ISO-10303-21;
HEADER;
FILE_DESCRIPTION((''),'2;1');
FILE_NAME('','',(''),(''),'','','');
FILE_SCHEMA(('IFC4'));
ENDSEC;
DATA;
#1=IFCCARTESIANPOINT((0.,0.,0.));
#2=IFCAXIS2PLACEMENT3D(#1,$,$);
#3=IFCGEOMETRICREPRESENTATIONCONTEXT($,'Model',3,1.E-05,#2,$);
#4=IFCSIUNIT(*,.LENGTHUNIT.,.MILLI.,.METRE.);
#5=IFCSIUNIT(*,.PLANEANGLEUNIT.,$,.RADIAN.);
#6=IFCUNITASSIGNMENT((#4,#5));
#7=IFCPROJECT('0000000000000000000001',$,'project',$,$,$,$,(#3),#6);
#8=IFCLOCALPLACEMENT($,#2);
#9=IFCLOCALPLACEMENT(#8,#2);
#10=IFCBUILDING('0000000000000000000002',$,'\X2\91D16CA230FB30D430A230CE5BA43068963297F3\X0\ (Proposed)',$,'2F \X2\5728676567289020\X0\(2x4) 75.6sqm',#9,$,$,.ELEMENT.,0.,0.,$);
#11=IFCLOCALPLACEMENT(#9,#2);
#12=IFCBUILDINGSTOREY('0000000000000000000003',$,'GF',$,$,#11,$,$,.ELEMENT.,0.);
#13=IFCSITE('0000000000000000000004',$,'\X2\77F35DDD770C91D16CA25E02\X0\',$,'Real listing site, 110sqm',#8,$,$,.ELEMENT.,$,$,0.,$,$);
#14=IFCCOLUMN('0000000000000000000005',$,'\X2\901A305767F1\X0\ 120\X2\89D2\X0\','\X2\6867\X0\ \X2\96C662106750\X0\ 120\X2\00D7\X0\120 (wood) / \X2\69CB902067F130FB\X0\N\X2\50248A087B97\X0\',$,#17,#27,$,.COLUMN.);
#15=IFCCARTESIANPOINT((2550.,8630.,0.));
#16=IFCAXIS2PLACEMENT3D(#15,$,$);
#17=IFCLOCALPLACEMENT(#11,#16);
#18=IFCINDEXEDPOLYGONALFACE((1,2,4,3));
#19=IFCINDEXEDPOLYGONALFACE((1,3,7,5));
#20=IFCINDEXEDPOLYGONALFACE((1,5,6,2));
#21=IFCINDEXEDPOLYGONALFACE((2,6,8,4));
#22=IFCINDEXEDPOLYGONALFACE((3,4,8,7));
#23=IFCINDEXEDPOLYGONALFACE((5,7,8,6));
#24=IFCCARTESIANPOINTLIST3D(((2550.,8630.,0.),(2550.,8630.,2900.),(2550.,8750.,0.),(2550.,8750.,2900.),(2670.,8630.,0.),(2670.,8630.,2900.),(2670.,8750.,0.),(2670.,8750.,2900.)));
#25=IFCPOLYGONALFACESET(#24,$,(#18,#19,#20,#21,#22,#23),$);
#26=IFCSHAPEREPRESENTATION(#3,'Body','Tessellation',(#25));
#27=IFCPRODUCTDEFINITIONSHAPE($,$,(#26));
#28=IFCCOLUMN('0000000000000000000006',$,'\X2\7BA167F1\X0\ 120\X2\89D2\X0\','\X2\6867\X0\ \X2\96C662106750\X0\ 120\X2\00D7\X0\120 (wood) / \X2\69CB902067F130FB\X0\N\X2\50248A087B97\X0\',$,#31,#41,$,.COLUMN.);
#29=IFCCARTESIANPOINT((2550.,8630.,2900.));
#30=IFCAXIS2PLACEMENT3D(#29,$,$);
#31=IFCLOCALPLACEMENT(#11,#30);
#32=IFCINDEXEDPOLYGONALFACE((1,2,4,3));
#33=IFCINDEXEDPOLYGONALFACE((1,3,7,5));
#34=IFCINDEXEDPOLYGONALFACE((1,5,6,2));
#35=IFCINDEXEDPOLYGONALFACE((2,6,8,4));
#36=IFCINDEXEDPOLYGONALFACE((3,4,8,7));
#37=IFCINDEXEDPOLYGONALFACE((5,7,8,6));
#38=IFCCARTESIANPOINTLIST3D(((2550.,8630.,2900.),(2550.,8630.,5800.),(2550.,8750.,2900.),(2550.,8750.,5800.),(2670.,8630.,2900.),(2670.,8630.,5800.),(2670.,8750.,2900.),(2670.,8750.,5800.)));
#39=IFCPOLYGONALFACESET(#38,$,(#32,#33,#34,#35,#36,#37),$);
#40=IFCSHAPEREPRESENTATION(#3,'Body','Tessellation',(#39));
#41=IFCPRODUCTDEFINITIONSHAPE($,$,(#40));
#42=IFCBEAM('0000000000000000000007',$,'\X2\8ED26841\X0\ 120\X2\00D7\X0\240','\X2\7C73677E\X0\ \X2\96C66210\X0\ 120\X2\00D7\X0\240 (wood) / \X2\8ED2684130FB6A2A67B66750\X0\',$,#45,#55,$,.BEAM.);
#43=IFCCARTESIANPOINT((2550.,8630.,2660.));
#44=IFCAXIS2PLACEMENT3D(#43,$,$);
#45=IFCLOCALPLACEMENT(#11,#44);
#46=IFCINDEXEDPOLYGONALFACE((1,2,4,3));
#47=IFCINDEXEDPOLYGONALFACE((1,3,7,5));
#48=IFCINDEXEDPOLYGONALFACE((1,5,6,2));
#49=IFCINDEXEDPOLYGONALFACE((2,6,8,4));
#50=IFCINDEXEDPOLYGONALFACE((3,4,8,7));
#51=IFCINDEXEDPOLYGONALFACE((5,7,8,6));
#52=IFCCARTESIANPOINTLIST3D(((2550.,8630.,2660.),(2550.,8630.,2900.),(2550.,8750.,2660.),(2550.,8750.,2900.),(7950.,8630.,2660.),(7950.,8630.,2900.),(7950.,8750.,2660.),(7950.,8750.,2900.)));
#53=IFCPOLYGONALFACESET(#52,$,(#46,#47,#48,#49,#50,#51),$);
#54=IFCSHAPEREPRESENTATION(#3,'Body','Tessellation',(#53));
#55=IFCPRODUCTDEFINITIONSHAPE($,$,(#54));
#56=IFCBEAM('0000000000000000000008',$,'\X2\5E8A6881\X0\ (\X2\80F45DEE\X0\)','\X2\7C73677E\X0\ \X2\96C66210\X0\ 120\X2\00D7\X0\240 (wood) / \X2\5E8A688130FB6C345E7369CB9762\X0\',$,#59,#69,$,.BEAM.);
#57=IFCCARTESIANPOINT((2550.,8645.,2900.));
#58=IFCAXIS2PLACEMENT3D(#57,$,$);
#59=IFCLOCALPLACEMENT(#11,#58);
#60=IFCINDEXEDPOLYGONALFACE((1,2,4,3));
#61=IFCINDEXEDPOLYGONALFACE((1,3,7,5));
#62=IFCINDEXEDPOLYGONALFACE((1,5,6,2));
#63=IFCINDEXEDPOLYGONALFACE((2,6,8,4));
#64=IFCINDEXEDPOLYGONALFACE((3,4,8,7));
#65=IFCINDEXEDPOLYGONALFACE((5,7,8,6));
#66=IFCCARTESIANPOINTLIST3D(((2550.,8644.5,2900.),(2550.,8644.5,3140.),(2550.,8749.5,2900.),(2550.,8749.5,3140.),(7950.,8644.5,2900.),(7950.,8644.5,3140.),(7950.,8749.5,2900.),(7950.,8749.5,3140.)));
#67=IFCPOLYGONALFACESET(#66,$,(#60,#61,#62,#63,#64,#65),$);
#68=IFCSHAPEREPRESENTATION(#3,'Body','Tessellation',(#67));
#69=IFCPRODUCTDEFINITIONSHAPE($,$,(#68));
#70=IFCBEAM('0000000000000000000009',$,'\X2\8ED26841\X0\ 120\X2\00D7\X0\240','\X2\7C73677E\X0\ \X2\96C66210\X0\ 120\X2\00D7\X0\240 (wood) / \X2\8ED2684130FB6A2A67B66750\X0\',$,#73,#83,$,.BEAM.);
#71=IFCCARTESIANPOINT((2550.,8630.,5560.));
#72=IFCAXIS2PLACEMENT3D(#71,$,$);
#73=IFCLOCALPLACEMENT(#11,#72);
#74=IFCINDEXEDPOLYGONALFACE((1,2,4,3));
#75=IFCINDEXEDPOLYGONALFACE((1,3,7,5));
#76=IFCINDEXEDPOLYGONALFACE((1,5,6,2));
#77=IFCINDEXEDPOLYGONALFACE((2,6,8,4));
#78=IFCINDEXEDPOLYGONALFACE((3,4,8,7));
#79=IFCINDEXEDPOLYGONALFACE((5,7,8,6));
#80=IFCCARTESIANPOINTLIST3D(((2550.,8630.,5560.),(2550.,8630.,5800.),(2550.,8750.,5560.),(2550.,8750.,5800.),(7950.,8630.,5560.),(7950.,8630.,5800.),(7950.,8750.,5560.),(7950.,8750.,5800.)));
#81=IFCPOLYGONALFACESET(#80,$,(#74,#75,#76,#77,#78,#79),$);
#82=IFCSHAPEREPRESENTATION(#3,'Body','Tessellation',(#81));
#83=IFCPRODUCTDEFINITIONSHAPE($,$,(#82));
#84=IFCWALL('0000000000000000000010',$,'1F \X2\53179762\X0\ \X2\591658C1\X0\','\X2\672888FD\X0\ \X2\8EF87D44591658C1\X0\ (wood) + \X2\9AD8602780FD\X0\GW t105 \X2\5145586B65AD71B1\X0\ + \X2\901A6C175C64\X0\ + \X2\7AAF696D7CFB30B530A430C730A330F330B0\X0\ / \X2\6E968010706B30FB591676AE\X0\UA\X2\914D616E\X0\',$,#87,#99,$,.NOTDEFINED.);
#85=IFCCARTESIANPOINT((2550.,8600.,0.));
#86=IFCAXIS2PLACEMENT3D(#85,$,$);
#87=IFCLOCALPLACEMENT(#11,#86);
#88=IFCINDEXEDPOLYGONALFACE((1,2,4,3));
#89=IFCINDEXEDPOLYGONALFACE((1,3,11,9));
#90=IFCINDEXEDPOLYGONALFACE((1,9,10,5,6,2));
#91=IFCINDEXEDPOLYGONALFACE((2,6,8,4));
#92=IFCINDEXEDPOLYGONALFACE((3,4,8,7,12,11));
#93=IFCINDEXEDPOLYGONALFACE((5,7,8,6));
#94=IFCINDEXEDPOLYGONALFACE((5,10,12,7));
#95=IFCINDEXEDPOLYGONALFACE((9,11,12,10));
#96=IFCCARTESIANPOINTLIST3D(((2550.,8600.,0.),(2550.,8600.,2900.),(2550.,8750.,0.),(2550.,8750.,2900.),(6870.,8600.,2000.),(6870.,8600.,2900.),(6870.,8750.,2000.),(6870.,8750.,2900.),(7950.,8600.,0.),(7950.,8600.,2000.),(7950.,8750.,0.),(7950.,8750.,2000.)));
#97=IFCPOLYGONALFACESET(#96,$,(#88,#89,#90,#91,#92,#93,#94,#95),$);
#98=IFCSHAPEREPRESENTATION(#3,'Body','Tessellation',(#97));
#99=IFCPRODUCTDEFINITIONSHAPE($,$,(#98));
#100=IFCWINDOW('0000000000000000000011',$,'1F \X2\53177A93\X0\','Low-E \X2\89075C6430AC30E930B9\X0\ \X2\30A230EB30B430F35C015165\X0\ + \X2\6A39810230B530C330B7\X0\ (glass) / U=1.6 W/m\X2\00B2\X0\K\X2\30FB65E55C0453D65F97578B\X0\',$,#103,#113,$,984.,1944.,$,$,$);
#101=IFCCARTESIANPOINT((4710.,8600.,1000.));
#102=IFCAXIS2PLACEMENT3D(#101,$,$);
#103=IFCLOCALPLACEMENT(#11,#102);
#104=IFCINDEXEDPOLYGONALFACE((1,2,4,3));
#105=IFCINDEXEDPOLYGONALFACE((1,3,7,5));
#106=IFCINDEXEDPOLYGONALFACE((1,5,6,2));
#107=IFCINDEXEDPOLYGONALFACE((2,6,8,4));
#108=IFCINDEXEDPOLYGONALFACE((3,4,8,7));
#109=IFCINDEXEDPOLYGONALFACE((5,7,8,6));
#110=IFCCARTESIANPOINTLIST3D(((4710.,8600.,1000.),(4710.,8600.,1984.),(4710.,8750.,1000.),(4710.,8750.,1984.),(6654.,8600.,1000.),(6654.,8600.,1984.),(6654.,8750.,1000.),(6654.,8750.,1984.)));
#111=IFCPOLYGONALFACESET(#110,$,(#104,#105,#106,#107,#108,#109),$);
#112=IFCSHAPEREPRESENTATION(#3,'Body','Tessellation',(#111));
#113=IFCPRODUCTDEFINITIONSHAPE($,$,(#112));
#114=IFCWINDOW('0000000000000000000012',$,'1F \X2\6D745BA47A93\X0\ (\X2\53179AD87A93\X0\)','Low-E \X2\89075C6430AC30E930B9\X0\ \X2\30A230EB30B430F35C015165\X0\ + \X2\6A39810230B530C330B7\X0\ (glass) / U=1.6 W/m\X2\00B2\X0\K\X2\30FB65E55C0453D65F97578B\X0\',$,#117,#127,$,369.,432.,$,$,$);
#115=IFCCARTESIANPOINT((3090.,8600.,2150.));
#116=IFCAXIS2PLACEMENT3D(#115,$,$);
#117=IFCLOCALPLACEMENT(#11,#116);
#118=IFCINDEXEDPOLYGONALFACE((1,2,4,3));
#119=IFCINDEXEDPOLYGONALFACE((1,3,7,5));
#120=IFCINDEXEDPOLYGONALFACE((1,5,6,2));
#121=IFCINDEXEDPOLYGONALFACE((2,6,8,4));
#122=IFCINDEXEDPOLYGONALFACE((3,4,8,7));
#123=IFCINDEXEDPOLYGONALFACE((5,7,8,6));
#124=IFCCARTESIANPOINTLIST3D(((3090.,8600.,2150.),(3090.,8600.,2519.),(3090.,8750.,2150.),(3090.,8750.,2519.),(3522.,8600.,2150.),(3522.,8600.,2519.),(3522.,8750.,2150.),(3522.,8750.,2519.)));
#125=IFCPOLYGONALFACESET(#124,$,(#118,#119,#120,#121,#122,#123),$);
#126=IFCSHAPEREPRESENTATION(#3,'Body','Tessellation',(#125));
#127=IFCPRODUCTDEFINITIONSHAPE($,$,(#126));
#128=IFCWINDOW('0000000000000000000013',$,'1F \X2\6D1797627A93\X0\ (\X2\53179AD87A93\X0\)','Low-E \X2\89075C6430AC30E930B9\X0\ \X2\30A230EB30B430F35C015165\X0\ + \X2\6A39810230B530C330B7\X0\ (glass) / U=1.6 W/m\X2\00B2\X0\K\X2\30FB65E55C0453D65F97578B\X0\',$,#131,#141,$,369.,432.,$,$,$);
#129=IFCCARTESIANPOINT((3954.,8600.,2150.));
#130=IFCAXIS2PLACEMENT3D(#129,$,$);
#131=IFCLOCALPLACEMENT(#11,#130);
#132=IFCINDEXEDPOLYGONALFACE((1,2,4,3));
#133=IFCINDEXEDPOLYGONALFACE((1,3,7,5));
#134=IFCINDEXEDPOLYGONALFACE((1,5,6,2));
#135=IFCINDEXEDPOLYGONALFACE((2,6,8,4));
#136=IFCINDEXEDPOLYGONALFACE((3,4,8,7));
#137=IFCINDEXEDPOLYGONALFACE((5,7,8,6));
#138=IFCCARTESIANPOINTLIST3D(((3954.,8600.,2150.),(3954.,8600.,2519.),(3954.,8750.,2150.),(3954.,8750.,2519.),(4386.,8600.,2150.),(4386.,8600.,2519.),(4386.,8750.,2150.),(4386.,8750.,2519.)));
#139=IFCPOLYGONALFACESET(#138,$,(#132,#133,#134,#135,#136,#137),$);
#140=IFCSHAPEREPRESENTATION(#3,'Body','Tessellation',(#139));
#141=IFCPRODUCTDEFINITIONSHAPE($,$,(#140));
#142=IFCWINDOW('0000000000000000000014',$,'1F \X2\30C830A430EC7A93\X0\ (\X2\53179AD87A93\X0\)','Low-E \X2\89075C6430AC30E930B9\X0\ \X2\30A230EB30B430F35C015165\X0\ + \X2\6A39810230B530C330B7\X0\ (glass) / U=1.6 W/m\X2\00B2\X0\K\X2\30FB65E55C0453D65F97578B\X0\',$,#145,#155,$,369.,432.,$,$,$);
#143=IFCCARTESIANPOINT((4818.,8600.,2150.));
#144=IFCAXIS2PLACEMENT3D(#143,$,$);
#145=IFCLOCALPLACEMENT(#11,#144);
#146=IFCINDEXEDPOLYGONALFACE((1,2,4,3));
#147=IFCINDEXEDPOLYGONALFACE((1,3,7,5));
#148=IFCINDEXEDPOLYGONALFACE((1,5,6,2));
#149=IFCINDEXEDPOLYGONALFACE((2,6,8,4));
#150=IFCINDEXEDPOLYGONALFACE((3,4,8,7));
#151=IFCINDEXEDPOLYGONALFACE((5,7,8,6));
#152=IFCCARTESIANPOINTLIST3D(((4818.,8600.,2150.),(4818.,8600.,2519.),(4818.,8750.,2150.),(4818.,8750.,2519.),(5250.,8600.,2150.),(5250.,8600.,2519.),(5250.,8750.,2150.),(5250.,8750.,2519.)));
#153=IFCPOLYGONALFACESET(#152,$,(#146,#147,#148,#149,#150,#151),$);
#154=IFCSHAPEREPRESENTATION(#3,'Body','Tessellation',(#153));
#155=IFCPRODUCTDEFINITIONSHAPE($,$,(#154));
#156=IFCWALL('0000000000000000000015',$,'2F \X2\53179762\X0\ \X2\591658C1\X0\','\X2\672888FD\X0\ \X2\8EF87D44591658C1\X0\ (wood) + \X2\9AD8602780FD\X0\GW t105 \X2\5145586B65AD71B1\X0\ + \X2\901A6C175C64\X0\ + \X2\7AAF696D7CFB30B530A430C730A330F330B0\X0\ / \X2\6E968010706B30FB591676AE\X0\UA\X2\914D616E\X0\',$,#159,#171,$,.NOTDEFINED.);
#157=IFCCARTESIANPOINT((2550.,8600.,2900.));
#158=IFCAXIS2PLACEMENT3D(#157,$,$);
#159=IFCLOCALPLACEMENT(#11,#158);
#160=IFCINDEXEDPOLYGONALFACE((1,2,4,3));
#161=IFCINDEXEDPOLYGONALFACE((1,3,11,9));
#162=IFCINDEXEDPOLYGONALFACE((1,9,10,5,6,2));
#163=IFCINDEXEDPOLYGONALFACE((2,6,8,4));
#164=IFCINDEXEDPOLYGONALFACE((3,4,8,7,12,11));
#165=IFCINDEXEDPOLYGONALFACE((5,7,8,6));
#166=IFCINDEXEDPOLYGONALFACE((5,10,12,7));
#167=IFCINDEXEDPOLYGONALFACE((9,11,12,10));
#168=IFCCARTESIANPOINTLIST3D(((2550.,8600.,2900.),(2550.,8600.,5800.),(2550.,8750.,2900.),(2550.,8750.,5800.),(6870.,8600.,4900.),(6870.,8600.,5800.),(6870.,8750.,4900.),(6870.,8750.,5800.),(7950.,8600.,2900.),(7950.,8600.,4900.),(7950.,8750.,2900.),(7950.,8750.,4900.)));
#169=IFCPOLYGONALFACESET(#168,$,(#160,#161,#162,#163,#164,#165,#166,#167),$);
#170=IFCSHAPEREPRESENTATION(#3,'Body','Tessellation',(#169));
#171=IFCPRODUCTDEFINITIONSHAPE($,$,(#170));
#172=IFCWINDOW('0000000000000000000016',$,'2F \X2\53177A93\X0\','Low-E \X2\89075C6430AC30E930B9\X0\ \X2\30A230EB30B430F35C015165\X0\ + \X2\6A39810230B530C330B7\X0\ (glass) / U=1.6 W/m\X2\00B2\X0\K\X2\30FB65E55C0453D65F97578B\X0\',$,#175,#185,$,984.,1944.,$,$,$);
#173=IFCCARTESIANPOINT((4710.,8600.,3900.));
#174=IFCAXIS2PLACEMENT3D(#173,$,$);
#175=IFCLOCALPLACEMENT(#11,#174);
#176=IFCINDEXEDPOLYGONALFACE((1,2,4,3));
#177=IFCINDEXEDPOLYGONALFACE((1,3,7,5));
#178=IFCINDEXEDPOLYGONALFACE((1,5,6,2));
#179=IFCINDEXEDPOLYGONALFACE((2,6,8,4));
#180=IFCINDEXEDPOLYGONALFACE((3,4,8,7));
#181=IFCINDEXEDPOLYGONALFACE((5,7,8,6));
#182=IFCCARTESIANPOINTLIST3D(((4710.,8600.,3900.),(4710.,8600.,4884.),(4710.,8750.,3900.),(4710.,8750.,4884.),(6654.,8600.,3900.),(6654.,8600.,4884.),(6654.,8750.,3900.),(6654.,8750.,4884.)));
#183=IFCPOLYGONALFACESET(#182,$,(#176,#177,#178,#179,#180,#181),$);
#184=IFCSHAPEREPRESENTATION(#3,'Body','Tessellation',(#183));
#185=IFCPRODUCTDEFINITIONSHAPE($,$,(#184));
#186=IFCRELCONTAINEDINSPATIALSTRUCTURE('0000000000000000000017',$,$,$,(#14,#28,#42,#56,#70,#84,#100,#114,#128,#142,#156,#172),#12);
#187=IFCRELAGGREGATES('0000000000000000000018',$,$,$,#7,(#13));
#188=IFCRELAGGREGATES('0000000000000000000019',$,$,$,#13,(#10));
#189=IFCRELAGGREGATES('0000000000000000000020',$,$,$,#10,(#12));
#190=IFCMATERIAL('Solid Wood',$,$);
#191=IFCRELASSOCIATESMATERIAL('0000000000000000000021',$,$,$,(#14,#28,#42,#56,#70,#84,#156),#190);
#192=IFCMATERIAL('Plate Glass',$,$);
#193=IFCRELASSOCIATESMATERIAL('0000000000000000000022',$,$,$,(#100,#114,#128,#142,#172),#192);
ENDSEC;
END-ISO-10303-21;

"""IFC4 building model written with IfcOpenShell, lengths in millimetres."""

from ifc_helpers import new_model, si_unit, frame, frame_2d, origin, place, context, project, spatial, rectangle, extrude, material, element, fill, save


model = new_model("IFC4")

# Units and contexts
model_context = context("Model", 3, precision=1e-05, world=origin())
ifc_project = project(units=[si_unit("LENGTHUNIT", "METRE", prefix="MILLI"), si_unit("PLANEANGLEUNIT", "RADIAN")], contexts=[model_context])

# Site, building, storey
site_placement = place(None, origin())
site = spatial("IfcSite", under=ifc_project, at=site_placement, Name="石川県金沢市", ObjectType="Real listing site, 110sqm", CompositionType="ELEMENT", RefElevation=0.0)
building_placement = place(site_placement, origin())
building = spatial("IfcBuilding", under=site, at=building_placement, Name="金沢・ピアノ室と防音 (Proposed)", ObjectType="2F 在来木造(2x4) 75.6sqm", CompositionType="ELEMENT", ElevationOfRefHeight=0.0, ElevationOfTerrain=0.0)
storey_placement = place(building_placement, origin())
storey = spatial("IfcBuildingStorey", under=building, at=storey_placement, Name="GF", CompositionType="ELEMENT", Elevation=0.0)

# Columns
ifc_material_1 = material(Name="Solid Wood")
column_1_placement = place(storey_placement, frame((2550.0, 8630.0, 0.0)))
element("IfcColumn", 1, at=column_1_placement, inside=storey, material=ifc_material_1, Name="通し柱 120角", Description="桧 集成材 120×120 (wood) / 構造柱・N値計算", PredefinedType="COLUMN", context=model_context, shape_type="SweptSolid", body=[
    extrude(rectangle(XDim=120.0, YDim=120.0, at=frame_2d((60.0, 60.0))), frame((2550.0, 8630.0, 0.0)), (0.0, 0.0, 1.0), 2900.0),
])
column_2_placement = place(storey_placement, frame((2550.0, 8630.0, 2900.0)))
element("IfcColumn", 2, at=column_2_placement, inside=storey, material=ifc_material_1, Name="管柱 120角", Description="桧 集成材 120×120 (wood) / 構造柱・N値計算", PredefinedType="COLUMN", context=model_context, shape_type="SweptSolid", body=[
    extrude(rectangle(XDim=120.0, YDim=120.0, at=frame_2d((60.0, 60.0))), frame((2550.0, 8630.0, 2900.0)), (0.0, 0.0, 1.0), 2900.0),
])

# Beams
beam_1_placement = place(storey_placement, frame((2550.0, 8630.0, 2660.0)))
element("IfcBeam", 3, at=beam_1_placement, inside=storey, material=ifc_material_1, Name="軒桁 120×240", Description="米松 集成 120×240 (wood) / 軒桁・横架材", PredefinedType="BEAM", context=model_context, shape_type="SweptSolid", body=[
    extrude(rectangle(XDim=5400.0, YDim=120.0, at=frame_2d((2700.0, 60.0))), frame((2550.0, 8630.0, 2660.0)), (0.0, 0.0, 1.0), 240.0),
])
beam_2_placement = place(storey_placement, frame((2550.0, 8645.0, 2900.0)))
element("IfcBeam", 4, at=beam_2_placement, inside=storey, material=ifc_material_1, Name="床梁 (胴差)", Description="米松 集成 120×240 (wood) / 床梁・水平構面", PredefinedType="BEAM", context=model_context, shape_type="SweptSolid", body=[
    extrude(rectangle(XDim=5400.0, YDim=105.0, at=frame_2d((2700.0, 52.0))), frame((2550.0, 8645.0, 2900.0)), (0.0, 0.0, 1.0), 240.0),
])
beam_3_placement = place(storey_placement, frame((2550.0, 8630.0, 5560.0)))
element("IfcBeam", 5, at=beam_3_placement, inside=storey, material=ifc_material_1, Name="軒桁 120×240", Description="米松 集成 120×240 (wood) / 軒桁・横架材", PredefinedType="BEAM", context=model_context, shape_type="SweptSolid", body=[
    extrude(rectangle(XDim=5400.0, YDim=120.0, at=frame_2d((2700.0, 60.0))), frame((2550.0, 8630.0, 5560.0)), (0.0, 0.0, 1.0), 240.0),
])

# Wall, openings, windows
wall_1_placement = place(storey_placement, frame((2550.0, 8600.0, 0.0)))
wall_1 = element("IfcWall", 6, at=wall_1_placement, inside=storey, material=ifc_material_1, Name="1F 北面 外壁", Description="木製 軸組外壁 (wood) + 高性能GW t105 充填断熱 + 通気層 + 窯業系サイディング / 準耐火・外皮UA配慮", PredefinedType="NOTDEFINED", context=model_context, shape_type="SweptSolid", body=[
    extrude(rectangle(XDim=5400.0, YDim=150.0, at=frame_2d((2700.0, 75.0))), frame((2550.0, 8600.0, 0.0)), (0.0, 0.0, 1.0), 2900.0),
])
opening_1_placement = place(storey_placement, frame((4710.0, 8600.0, 1000.0)))
opening_1 = element("IfcOpeningElement", 7, at=opening_1_placement, cuts=wall_1, PredefinedType="NOTDEFINED", context=model_context, shape_type="SweptSolid", body=[
    extrude(rectangle(XDim=1944.0, YDim=150.0, at=frame_2d((972.0, 75.0))), frame((4710.0, 8600.0, 1000.0)), (0.0, 0.0, 1.0), 984.0),
])
opening_2_placement = place(storey_placement, frame((3090.0, 8600.0, 2150.0)))
opening_2 = element("IfcOpeningElement", 8, at=opening_2_placement, cuts=wall_1, PredefinedType="NOTDEFINED", context=model_context, shape_type="SweptSolid", body=[
    extrude(rectangle(XDim=432.0, YDim=150.0, at=frame_2d((216.0, 75.0))), frame((3090.0, 8600.0, 2150.0)), (0.0, 0.0, 1.0), 369.0),
])
opening_3_placement = place(storey_placement, frame((3954.0, 8600.0, 2150.0)))
opening_3 = element("IfcOpeningElement", 9, at=opening_3_placement, cuts=wall_1, PredefinedType="NOTDEFINED", context=model_context, shape_type="SweptSolid", body=[
    extrude(rectangle(XDim=432.0, YDim=150.0, at=frame_2d((216.0, 75.0))), frame((3954.0, 8600.0, 2150.0)), (0.0, 0.0, 1.0), 369.0),
])
opening_4_placement = place(storey_placement, frame((4818.0, 8600.0, 2150.0)))
opening_4 = element("IfcOpeningElement", 10, at=opening_4_placement, cuts=wall_1, PredefinedType="NOTDEFINED", context=model_context, shape_type="SweptSolid", body=[
    extrude(rectangle(XDim=432.0, YDim=150.0, at=frame_2d((216.0, 75.0))), frame((4818.0, 8600.0, 2150.0)), (0.0, 0.0, 1.0), 369.0),
])
ifc_material_2 = material(Name="Plate Glass")
window_1_placement = place(storey_placement, frame((4710.0, 8600.0, 1000.0)))
window_1 = element("IfcWindow", 11, at=window_1_placement, inside=storey, material=ifc_material_2, Name="1F 北窓", Description="Low-E 複層ガラス アルゴン封入 + 樹脂サッシ (glass) / U=1.6 W/m²K・日射取得型", OverallHeight=984.0, OverallWidth=1944.0, context=model_context, shape_type="SweptSolid", body=[
    extrude(rectangle(XDim=1944.0, YDim=150.0, at=frame_2d((972.0, 75.0))), frame((4710.0, 8600.0, 1000.0)), (0.0, 0.0, 1.0), 984.0),
])
fill(opening_1, window_1)
window_2_placement = place(storey_placement, frame((3090.0, 8600.0, 2150.0)))
window_2 = element("IfcWindow", 12, at=window_2_placement, inside=storey, material=ifc_material_2, Name="1F 浴室窓 (北高窓)", Description="Low-E 複層ガラス アルゴン封入 + 樹脂サッシ (glass) / U=1.6 W/m²K・日射取得型", OverallHeight=369.0, OverallWidth=432.0, context=model_context, shape_type="SweptSolid", body=[
    extrude(rectangle(XDim=432.0, YDim=150.0, at=frame_2d((216.0, 75.0))), frame((3090.0, 8600.0, 2150.0)), (0.0, 0.0, 1.0), 369.0),
])
fill(opening_2, window_2)
window_3_placement = place(storey_placement, frame((3954.0, 8600.0, 2150.0)))
window_3 = element("IfcWindow", 13, at=window_3_placement, inside=storey, material=ifc_material_2, Name="1F 洗面窓 (北高窓)", Description="Low-E 複層ガラス アルゴン封入 + 樹脂サッシ (glass) / U=1.6 W/m²K・日射取得型", OverallHeight=369.0, OverallWidth=432.0, context=model_context, shape_type="SweptSolid", body=[
    extrude(rectangle(XDim=432.0, YDim=150.0, at=frame_2d((216.0, 75.0))), frame((3954.0, 8600.0, 2150.0)), (0.0, 0.0, 1.0), 369.0),
])
fill(opening_3, window_3)
window_4_placement = place(storey_placement, frame((4818.0, 8600.0, 2150.0)))
window_4 = element("IfcWindow", 14, at=window_4_placement, inside=storey, material=ifc_material_2, Name="1F トイレ窓 (北高窓)", Description="Low-E 複層ガラス アルゴン封入 + 樹脂サッシ (glass) / U=1.6 W/m²K・日射取得型", OverallHeight=369.0, OverallWidth=432.0, context=model_context, shape_type="SweptSolid", body=[
    extrude(rectangle(XDim=432.0, YDim=150.0, at=frame_2d((216.0, 75.0))), frame((4818.0, 8600.0, 2150.0)), (0.0, 0.0, 1.0), 369.0),
])
fill(opening_4, window_4)

# Wall, opening, window
wall_2_placement = place(storey_placement, frame((2550.0, 8600.0, 2900.0)))
wall_2 = element("IfcWall", 15, at=wall_2_placement, inside=storey, material=ifc_material_1, Name="2F 北面 外壁", Description="木製 軸組外壁 (wood) + 高性能GW t105 充填断熱 + 通気層 + 窯業系サイディング / 準耐火・外皮UA配慮", PredefinedType="NOTDEFINED", context=model_context, shape_type="SweptSolid", body=[
    extrude(rectangle(XDim=5400.0, YDim=150.0, at=frame_2d((2700.0, 75.0))), frame((2550.0, 8600.0, 2900.0)), (0.0, 0.0, 1.0), 2900.0),
])
opening_5_placement = place(storey_placement, frame((4710.0, 8600.0, 3900.0)))
opening_5 = element("IfcOpeningElement", 16, at=opening_5_placement, cuts=wall_2, PredefinedType="NOTDEFINED", context=model_context, shape_type="SweptSolid", body=[
    extrude(rectangle(XDim=1944.0, YDim=150.0, at=frame_2d((972.0, 75.0))), frame((4710.0, 8600.0, 3900.0)), (0.0, 0.0, 1.0), 984.0),
])
window_5_placement = place(storey_placement, frame((4710.0, 8600.0, 3900.0)))
window_5 = element("IfcWindow", 17, at=window_5_placement, inside=storey, material=ifc_material_2, Name="2F 北窓", Description="Low-E 複層ガラス アルゴン封入 + 樹脂サッシ (glass) / U=1.6 W/m²K・日射取得型", OverallHeight=984.0, OverallWidth=1944.0, context=model_context, shape_type="SweptSolid", body=[
    extrude(rectangle(XDim=1944.0, YDim=150.0, at=frame_2d((972.0, 75.0))), frame((4710.0, 8600.0, 3900.0)), (0.0, 0.0, 1.0), 984.0),
])
fill(opening_5, window_5)

save(model, "model.ifc")
